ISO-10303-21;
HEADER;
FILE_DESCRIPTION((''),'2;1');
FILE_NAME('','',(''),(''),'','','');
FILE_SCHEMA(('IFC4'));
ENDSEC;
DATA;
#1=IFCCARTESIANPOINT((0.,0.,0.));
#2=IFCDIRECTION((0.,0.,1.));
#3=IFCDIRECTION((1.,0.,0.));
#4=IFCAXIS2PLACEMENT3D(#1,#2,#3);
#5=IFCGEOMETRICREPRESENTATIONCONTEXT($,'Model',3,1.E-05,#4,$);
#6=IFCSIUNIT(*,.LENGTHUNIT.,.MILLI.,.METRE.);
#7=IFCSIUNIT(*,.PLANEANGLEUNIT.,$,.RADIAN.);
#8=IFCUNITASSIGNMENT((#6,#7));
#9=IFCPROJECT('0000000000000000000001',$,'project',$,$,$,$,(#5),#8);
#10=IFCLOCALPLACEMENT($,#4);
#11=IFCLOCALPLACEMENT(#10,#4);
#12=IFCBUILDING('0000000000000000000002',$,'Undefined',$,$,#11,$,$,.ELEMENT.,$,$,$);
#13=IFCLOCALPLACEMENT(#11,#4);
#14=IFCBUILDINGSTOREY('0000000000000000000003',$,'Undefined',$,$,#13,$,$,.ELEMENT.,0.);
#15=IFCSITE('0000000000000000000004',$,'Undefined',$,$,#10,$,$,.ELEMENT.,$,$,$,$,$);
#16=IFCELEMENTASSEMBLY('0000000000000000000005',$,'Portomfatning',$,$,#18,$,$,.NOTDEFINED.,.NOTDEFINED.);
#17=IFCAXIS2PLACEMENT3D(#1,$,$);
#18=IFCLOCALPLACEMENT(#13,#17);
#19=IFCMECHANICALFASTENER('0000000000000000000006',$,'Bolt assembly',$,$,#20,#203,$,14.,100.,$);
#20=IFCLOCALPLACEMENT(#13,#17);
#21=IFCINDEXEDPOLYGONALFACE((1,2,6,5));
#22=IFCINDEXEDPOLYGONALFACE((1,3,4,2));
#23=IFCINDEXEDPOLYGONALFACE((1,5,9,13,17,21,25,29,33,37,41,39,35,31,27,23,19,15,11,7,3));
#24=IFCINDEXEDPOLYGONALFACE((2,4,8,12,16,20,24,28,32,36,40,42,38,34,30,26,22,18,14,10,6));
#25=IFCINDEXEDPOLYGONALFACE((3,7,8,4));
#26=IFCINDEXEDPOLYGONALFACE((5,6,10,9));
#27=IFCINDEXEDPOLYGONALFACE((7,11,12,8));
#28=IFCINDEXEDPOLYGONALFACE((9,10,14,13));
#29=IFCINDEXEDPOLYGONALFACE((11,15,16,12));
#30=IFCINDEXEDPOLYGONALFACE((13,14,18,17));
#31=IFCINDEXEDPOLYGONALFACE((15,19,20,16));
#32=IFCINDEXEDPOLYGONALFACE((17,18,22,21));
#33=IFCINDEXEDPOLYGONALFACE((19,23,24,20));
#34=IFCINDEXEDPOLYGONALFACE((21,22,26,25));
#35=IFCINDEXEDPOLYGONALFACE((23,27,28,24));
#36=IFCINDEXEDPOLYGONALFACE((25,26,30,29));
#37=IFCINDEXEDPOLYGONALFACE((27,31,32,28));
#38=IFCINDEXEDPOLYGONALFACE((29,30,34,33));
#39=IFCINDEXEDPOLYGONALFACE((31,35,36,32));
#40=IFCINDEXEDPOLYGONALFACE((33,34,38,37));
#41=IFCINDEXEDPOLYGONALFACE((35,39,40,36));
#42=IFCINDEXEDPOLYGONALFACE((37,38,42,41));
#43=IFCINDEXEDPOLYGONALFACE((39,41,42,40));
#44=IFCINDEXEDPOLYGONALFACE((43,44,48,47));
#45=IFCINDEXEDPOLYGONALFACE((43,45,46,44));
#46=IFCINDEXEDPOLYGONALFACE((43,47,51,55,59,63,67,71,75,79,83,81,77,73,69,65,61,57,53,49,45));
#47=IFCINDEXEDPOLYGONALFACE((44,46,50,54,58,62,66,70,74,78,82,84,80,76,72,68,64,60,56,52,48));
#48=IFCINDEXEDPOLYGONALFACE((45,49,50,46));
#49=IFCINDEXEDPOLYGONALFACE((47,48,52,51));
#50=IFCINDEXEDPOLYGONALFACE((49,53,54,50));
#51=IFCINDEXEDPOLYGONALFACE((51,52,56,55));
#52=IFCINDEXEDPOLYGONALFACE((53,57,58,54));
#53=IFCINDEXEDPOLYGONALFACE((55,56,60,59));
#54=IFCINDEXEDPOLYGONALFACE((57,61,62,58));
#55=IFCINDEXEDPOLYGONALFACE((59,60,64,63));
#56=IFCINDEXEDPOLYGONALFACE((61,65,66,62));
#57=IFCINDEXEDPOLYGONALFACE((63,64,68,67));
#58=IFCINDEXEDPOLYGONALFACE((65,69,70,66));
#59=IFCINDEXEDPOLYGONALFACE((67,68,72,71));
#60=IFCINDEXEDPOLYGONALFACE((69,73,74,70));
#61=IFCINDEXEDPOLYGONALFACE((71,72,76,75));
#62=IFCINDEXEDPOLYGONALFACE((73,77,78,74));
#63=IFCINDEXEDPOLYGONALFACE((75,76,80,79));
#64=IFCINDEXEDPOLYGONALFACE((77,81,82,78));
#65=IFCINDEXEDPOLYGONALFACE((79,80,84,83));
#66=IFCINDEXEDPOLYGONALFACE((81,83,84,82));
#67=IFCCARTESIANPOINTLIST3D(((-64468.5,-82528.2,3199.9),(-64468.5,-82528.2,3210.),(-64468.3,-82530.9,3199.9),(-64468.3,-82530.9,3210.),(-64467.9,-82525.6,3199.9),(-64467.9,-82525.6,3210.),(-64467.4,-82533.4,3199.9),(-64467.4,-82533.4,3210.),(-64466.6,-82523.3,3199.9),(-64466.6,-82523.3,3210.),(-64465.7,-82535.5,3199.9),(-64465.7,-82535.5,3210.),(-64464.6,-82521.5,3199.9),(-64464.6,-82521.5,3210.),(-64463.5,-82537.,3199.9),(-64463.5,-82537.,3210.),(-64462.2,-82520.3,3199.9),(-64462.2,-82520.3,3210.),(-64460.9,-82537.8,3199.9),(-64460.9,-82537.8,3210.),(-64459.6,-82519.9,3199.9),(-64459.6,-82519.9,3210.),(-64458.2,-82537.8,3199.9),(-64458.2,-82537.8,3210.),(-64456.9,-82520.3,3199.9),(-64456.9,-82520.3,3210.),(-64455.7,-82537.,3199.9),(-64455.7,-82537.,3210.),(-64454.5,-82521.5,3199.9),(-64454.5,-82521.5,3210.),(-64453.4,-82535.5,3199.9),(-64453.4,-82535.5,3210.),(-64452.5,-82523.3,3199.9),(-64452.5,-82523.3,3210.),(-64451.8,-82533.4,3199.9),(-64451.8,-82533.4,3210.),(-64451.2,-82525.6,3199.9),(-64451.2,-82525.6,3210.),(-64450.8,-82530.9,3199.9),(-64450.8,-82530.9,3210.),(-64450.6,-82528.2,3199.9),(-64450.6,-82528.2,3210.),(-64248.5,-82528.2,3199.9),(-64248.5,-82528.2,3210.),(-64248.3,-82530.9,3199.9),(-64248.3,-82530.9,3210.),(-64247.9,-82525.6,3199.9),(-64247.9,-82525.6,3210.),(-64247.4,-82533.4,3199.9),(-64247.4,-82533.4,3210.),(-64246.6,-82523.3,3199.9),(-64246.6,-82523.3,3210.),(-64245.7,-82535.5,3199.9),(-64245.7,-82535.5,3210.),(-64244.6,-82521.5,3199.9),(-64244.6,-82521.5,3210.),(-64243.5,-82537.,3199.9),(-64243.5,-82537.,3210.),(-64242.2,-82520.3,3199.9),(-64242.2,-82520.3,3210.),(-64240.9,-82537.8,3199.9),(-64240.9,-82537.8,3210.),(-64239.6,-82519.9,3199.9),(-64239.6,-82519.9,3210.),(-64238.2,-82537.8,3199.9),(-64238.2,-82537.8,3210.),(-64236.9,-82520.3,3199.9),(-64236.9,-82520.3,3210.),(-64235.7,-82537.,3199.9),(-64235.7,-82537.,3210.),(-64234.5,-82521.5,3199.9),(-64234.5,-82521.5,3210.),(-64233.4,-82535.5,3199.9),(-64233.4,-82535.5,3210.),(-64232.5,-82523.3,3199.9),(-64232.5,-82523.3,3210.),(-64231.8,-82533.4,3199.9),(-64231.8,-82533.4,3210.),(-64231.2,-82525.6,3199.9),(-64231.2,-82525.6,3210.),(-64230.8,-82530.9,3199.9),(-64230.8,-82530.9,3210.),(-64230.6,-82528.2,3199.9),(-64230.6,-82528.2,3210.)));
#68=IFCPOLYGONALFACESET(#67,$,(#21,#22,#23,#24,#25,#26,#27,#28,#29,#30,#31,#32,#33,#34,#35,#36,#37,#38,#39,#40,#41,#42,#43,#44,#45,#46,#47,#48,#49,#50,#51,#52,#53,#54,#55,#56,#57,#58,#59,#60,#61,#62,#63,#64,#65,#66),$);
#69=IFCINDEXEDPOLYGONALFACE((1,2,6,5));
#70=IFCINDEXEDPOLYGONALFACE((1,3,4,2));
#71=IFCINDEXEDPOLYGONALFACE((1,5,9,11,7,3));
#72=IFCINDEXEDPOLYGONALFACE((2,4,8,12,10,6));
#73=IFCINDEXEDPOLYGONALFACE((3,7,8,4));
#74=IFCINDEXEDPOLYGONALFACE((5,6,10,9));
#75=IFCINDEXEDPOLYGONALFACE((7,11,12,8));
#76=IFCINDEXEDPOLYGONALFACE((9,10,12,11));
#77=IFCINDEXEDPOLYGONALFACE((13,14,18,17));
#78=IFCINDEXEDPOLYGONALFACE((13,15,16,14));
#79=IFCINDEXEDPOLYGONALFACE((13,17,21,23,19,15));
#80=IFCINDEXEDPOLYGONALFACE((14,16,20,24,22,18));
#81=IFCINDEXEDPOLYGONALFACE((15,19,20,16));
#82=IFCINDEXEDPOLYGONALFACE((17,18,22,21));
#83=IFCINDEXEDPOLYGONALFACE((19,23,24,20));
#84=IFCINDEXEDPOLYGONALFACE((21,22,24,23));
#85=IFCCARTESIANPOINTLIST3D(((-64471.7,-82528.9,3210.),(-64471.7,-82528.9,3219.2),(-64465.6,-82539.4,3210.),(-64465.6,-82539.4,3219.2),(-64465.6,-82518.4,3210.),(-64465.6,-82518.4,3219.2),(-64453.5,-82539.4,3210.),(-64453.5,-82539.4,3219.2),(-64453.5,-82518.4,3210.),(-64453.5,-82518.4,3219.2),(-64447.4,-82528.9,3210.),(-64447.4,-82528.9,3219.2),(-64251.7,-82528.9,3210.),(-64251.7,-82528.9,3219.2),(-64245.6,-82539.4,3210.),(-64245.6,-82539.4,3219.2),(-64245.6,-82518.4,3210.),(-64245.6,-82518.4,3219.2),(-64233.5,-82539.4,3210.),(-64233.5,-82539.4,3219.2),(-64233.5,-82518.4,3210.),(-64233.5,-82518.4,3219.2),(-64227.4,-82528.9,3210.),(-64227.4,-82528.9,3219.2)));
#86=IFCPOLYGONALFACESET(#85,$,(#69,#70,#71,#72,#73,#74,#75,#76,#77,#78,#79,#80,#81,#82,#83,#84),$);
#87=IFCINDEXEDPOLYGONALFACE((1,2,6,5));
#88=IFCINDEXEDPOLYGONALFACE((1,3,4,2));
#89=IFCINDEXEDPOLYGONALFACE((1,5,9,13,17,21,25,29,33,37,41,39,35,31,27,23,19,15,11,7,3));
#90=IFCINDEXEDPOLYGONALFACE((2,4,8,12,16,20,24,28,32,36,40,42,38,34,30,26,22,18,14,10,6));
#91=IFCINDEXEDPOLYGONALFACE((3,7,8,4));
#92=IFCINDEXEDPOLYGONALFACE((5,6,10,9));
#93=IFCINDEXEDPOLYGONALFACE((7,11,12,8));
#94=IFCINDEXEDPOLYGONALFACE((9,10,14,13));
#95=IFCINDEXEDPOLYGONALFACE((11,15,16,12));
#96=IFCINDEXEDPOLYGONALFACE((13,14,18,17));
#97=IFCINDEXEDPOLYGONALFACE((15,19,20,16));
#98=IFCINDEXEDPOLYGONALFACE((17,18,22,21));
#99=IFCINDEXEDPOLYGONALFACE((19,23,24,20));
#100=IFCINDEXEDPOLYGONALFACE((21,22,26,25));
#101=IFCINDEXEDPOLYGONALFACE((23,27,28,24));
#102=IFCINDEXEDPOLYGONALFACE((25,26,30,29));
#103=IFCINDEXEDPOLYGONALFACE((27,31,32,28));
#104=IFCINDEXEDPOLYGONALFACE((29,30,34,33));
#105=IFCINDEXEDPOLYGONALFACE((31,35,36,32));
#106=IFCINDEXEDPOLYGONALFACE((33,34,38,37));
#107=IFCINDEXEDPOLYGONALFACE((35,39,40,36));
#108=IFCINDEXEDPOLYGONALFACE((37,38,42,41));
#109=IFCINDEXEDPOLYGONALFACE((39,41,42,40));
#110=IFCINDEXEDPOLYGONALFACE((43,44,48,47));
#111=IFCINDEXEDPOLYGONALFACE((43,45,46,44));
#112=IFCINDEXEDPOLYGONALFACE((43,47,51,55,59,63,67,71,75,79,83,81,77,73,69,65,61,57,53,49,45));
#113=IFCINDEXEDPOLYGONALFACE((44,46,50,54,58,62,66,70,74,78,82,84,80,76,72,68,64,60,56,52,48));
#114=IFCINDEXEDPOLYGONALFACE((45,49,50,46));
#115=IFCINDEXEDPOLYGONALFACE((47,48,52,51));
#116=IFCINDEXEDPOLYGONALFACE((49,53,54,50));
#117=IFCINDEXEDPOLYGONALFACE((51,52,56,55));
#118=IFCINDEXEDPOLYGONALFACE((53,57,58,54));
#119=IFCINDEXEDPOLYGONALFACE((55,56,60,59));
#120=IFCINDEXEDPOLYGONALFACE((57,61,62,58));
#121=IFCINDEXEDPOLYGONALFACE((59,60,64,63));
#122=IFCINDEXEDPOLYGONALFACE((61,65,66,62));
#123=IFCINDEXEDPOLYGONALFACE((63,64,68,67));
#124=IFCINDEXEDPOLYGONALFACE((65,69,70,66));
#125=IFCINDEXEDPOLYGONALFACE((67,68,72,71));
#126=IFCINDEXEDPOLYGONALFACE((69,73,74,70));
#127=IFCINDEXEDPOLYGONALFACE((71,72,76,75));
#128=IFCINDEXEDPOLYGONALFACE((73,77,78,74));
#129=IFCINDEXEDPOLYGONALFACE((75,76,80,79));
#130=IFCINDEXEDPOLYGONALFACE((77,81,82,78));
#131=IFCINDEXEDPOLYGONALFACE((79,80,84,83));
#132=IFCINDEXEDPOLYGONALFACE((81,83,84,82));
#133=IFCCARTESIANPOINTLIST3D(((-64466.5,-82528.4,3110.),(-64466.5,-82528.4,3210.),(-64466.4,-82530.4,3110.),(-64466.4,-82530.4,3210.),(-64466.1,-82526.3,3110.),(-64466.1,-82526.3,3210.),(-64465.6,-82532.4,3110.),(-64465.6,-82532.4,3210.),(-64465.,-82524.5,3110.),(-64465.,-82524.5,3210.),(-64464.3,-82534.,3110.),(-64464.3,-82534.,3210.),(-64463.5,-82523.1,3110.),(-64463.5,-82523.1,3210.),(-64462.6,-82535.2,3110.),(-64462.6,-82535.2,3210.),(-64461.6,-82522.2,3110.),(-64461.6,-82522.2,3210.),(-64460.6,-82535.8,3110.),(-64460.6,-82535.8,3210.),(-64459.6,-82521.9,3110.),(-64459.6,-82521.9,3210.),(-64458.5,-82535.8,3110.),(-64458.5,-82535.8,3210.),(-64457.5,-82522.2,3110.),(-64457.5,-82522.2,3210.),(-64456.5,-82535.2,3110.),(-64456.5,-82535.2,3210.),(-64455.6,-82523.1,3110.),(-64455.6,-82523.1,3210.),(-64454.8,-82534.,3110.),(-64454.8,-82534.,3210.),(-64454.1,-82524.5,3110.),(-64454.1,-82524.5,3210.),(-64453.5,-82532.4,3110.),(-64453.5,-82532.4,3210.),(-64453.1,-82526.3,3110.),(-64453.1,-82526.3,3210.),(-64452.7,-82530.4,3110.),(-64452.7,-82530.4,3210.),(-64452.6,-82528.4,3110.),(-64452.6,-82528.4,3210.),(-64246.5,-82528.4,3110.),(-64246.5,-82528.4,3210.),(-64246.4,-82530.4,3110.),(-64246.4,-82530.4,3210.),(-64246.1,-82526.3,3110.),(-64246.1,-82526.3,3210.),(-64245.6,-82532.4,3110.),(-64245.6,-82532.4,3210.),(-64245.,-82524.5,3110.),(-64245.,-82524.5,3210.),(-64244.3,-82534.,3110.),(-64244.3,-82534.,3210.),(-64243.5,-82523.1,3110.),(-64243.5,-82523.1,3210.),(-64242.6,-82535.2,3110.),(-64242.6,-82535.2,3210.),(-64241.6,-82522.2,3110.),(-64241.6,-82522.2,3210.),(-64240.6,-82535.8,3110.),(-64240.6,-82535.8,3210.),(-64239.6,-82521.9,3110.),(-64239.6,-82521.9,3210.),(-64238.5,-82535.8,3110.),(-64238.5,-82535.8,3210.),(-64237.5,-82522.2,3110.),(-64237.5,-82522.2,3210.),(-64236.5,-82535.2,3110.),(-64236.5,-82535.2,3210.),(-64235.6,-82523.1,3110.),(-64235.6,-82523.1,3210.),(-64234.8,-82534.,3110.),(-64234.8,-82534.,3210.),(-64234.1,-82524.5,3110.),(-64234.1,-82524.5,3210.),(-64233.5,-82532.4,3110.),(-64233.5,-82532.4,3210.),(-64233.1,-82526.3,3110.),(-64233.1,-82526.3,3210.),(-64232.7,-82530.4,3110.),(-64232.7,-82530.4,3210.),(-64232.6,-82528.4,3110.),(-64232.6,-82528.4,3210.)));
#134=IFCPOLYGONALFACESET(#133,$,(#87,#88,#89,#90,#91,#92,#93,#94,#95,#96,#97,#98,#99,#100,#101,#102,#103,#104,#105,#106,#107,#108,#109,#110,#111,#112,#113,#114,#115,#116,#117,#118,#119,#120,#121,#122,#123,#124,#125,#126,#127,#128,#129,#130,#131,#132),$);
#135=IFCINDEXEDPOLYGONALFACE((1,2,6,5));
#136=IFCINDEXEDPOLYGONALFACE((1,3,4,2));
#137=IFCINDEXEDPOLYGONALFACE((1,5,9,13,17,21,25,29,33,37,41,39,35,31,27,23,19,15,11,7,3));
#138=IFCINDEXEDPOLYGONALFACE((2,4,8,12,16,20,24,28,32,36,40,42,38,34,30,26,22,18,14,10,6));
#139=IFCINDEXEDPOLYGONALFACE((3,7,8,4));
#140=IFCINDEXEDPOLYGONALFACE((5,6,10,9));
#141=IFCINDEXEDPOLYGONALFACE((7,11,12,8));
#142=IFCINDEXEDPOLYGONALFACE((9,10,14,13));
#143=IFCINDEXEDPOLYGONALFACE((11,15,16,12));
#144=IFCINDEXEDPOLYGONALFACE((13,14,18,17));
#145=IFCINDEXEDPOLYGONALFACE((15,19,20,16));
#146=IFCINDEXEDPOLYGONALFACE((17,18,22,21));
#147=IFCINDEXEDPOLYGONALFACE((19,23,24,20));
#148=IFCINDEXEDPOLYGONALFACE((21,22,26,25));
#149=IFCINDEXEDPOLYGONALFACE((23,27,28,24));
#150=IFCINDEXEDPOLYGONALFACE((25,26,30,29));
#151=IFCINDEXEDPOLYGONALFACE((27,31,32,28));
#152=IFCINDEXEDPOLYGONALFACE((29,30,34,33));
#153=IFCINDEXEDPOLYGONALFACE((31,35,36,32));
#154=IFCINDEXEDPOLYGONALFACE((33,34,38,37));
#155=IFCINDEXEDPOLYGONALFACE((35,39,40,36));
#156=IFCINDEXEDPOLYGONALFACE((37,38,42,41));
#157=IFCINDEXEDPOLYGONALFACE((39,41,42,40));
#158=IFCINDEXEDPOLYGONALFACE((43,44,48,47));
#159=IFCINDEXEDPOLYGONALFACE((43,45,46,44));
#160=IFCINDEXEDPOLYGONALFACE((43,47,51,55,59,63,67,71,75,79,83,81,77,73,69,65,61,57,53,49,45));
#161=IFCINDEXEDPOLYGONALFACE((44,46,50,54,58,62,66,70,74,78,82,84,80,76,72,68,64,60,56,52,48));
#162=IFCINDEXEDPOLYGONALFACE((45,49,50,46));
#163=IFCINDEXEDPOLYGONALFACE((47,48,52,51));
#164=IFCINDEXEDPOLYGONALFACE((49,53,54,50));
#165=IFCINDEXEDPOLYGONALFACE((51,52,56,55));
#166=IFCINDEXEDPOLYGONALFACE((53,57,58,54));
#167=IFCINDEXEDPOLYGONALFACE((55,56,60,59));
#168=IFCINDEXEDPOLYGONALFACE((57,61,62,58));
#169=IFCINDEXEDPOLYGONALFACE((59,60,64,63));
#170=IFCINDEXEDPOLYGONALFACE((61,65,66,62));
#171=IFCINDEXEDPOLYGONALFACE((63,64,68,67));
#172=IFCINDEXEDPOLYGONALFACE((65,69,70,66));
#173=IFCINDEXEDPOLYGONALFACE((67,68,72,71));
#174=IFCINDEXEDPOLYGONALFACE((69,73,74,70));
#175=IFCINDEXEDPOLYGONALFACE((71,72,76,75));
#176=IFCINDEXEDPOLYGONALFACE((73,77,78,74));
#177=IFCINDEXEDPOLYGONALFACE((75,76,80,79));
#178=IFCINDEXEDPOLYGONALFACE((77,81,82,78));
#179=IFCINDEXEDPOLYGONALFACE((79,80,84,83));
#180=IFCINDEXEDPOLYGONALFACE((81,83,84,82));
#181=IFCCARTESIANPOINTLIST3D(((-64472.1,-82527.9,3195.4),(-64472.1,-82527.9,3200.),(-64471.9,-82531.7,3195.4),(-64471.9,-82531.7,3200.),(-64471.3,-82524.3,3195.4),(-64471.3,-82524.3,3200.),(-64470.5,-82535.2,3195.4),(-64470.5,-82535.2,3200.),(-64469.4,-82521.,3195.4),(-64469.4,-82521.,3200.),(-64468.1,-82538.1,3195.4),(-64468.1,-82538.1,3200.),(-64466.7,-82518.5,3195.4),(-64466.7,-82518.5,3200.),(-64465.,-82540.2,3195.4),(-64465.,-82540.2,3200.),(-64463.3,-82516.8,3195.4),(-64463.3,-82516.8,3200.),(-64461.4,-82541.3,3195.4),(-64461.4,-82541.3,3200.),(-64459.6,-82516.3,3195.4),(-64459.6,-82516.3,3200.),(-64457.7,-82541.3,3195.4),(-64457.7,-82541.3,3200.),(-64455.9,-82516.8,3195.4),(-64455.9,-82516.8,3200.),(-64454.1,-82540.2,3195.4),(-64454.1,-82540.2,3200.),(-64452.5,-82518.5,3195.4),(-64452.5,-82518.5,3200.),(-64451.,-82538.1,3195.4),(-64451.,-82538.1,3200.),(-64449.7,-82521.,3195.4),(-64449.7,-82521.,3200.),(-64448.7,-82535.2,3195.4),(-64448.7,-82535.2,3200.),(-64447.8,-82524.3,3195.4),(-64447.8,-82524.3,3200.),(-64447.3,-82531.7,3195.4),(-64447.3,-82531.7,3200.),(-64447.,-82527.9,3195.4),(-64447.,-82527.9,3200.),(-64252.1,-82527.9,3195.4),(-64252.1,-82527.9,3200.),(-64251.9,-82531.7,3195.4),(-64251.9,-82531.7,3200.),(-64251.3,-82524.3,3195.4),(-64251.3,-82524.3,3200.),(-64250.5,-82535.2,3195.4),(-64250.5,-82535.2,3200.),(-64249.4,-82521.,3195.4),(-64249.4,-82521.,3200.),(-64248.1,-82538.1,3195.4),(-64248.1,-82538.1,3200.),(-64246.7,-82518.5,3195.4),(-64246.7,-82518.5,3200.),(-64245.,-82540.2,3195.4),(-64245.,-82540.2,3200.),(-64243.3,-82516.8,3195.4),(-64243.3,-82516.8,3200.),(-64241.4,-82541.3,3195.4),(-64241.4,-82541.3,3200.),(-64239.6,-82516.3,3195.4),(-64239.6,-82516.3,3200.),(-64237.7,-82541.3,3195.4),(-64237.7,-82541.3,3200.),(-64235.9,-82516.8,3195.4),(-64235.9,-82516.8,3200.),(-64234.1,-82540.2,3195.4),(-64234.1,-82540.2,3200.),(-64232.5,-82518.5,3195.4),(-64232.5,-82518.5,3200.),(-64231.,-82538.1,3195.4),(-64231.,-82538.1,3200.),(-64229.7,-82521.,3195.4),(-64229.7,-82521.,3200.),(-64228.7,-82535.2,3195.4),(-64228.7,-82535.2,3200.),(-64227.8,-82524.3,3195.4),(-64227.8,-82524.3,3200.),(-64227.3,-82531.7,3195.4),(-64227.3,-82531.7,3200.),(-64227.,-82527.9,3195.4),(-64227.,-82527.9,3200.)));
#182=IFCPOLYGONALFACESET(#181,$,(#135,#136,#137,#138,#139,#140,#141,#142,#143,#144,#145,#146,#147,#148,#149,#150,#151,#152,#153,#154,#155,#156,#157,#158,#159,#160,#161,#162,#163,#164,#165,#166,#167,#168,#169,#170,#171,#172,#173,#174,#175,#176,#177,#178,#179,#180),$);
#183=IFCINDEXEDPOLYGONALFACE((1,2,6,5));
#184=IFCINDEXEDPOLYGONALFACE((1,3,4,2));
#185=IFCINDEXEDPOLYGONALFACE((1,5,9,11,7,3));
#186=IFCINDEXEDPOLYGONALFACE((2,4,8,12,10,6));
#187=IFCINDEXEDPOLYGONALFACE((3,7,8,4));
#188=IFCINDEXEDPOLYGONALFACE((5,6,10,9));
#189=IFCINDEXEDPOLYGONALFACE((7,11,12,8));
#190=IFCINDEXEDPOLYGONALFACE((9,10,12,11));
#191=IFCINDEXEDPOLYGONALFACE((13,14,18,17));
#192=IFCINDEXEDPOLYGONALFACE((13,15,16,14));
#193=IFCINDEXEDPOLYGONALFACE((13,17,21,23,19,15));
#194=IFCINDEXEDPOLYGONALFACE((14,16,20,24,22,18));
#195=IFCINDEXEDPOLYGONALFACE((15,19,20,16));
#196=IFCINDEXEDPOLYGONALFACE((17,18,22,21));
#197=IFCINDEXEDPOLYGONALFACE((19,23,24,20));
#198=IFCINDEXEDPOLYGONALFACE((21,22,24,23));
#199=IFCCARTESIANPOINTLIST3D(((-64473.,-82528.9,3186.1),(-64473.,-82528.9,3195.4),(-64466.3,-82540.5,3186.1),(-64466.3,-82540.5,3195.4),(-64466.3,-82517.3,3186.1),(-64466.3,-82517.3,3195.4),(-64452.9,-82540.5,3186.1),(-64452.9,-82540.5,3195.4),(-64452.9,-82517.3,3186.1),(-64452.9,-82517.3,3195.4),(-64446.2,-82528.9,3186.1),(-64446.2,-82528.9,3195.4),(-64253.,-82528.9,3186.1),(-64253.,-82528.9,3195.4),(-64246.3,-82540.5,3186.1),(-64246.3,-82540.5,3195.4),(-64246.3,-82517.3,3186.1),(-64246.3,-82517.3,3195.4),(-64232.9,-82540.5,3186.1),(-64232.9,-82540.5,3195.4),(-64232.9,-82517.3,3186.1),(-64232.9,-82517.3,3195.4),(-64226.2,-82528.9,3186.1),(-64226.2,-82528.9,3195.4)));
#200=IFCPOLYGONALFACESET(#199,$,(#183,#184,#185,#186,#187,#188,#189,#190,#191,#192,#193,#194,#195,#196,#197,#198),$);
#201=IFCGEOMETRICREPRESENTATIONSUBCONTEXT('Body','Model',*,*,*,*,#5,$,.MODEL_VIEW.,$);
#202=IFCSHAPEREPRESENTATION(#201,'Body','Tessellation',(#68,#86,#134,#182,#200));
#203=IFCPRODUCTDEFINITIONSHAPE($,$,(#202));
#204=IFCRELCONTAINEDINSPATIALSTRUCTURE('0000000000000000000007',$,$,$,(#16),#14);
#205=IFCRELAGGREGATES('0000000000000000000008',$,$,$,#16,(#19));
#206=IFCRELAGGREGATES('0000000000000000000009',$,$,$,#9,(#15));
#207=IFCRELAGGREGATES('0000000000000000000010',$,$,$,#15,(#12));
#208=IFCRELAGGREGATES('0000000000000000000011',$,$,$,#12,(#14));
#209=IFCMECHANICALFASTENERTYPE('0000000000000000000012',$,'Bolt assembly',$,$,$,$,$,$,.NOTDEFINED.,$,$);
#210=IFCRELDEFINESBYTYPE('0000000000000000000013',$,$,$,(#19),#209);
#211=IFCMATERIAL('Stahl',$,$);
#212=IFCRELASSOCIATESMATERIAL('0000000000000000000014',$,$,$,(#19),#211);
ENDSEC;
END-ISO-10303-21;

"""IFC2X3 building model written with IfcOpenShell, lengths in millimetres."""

from ifc_helpers import new_model, si_unit, frame, origin_with_axes, origin_2d_with_axis, place, context, subcontext, project, spatial, polyline, circle, outline, extrude, source, transform, mapped, material, type_object, element, aggregate, save


model = new_model("IFC2X3")

# Units and contexts
model_context = context("Model", 3, precision=1e-05, world=origin_with_axes())
body_context = subcontext(model_context, "Body", "Model", "MODEL_VIEW")
ifc_project = project(units=[si_unit("LENGTHUNIT", "METRE", prefix="MILLI"), si_unit("PLANEANGLEUNIT", "RADIAN")], contexts=[model_context])

# Site, building, storey
site_placement = place(None, origin_with_axes())
site = spatial("IfcSite", under=ifc_project, at=site_placement, Name="Undefined", CompositionType="ELEMENT")
building_placement = place(site_placement, origin_with_axes())
building = spatial("IfcBuilding", under=site, at=building_placement, Name="Undefined", CompositionType="ELEMENT")
storey_placement = place(building_placement, origin_with_axes())
storey = spatial("IfcBuildingStorey", under=building, at=storey_placement, Name="Undefined", CompositionType="ELEMENT", Elevation=0.0)

# Element assembly
assembly_1_placement = place(storey_placement, origin_with_axes())
assembly_1 = element("IfcElementAssembly", 1, at=assembly_1_placement, inside=storey, Name="Portomfatning", AssemblyPlace="NOTDEFINED", PredefinedType="NOTDEFINED")

# Mechanical fastener
ifc_material_1 = material(Name="Stahl")
mechanical_fastener_type = type_object("IfcMechanicalFastenerType", Name="Bolt assembly")
shared_shape_1 = source(origin_with_axes(), body_context, "Body", "SweptSolid", [
    extrude(circle(Radius=9.0, at=origin_2d_with_axis()), frame((0.0, 0.0, 0.0), z_axis=(0.0, 1.0, 0.0), x_axis=(1.0, 0.0, 0.0)), (0.0, 0.0, 1.0), 10.1),
    extrude(outline(polyline([(10.5, -6.1), (10.5, 6.1), (0.0, 12.1), (-10.5, 6.1), (-10.5, -6.1), (0.0, -12.1), (10.5, -6.1)])), frame((0.0, -9.2, 0.0), z_axis=(0.0, 1.0, 0.0), x_axis=(1.0, 0.0, 0.0)), (0.0, 0.0, 1.0), 9.2),
    extrude(circle(Radius=7.0, at=origin_2d_with_axis()), frame((0.0, 0.0, 0.0), z_axis=(0.0, 1.0, 0.0), x_axis=(1.0, 0.0, 0.0)), (0.0, 0.0, 1.0), 100.0),
    extrude(circle(Radius=12.6, at=origin_2d_with_axis()), frame((0.0, 10.0, 0.0), z_axis=(0.0, 1.0, 0.0), x_axis=(1.0, 0.0, 0.0)), (0.0, 0.0, 1.0), 4.6),
    extrude(outline(polyline([(11.6, -6.7), (11.6, 6.7), (0.0, 13.4), (-11.6, 6.7), (-11.6, -6.7), (0.0, -13.4), (11.6, -6.7)])), frame((0.0, 14.6, 0.0), z_axis=(0.0, 1.0, 0.0), x_axis=(1.0, 0.0, 0.0)), (0.0, 0.0, 1.0), 9.2),
])
mechanical_fastener_1_placement = place(assembly_1_placement, frame((-64349.6, -82528.9, 3210.0), z_axis=(-1.0, 0.0, 0.0), x_axis=(0.0, 1.0, 0.0)))
mechanical_fastener_1 = element("IfcMechanicalFastener", 2, at=mechanical_fastener_1_placement, type_object=mechanical_fastener_type, material=ifc_material_1, Name="Bolt assembly", NominalDiameter=14.0, NominalLength=100.0, context=body_context, shape_type="MappedRepresentation", body=[
    mapped(shared_shape_1, transform((0.0, 0.0, -110.0))),
    mapped(shared_shape_1, transform((0.0, 0.0, 110.0))),
])
aggregate(assembly_1, [mechanical_fastener_1])

save(model, "model.ifc")
